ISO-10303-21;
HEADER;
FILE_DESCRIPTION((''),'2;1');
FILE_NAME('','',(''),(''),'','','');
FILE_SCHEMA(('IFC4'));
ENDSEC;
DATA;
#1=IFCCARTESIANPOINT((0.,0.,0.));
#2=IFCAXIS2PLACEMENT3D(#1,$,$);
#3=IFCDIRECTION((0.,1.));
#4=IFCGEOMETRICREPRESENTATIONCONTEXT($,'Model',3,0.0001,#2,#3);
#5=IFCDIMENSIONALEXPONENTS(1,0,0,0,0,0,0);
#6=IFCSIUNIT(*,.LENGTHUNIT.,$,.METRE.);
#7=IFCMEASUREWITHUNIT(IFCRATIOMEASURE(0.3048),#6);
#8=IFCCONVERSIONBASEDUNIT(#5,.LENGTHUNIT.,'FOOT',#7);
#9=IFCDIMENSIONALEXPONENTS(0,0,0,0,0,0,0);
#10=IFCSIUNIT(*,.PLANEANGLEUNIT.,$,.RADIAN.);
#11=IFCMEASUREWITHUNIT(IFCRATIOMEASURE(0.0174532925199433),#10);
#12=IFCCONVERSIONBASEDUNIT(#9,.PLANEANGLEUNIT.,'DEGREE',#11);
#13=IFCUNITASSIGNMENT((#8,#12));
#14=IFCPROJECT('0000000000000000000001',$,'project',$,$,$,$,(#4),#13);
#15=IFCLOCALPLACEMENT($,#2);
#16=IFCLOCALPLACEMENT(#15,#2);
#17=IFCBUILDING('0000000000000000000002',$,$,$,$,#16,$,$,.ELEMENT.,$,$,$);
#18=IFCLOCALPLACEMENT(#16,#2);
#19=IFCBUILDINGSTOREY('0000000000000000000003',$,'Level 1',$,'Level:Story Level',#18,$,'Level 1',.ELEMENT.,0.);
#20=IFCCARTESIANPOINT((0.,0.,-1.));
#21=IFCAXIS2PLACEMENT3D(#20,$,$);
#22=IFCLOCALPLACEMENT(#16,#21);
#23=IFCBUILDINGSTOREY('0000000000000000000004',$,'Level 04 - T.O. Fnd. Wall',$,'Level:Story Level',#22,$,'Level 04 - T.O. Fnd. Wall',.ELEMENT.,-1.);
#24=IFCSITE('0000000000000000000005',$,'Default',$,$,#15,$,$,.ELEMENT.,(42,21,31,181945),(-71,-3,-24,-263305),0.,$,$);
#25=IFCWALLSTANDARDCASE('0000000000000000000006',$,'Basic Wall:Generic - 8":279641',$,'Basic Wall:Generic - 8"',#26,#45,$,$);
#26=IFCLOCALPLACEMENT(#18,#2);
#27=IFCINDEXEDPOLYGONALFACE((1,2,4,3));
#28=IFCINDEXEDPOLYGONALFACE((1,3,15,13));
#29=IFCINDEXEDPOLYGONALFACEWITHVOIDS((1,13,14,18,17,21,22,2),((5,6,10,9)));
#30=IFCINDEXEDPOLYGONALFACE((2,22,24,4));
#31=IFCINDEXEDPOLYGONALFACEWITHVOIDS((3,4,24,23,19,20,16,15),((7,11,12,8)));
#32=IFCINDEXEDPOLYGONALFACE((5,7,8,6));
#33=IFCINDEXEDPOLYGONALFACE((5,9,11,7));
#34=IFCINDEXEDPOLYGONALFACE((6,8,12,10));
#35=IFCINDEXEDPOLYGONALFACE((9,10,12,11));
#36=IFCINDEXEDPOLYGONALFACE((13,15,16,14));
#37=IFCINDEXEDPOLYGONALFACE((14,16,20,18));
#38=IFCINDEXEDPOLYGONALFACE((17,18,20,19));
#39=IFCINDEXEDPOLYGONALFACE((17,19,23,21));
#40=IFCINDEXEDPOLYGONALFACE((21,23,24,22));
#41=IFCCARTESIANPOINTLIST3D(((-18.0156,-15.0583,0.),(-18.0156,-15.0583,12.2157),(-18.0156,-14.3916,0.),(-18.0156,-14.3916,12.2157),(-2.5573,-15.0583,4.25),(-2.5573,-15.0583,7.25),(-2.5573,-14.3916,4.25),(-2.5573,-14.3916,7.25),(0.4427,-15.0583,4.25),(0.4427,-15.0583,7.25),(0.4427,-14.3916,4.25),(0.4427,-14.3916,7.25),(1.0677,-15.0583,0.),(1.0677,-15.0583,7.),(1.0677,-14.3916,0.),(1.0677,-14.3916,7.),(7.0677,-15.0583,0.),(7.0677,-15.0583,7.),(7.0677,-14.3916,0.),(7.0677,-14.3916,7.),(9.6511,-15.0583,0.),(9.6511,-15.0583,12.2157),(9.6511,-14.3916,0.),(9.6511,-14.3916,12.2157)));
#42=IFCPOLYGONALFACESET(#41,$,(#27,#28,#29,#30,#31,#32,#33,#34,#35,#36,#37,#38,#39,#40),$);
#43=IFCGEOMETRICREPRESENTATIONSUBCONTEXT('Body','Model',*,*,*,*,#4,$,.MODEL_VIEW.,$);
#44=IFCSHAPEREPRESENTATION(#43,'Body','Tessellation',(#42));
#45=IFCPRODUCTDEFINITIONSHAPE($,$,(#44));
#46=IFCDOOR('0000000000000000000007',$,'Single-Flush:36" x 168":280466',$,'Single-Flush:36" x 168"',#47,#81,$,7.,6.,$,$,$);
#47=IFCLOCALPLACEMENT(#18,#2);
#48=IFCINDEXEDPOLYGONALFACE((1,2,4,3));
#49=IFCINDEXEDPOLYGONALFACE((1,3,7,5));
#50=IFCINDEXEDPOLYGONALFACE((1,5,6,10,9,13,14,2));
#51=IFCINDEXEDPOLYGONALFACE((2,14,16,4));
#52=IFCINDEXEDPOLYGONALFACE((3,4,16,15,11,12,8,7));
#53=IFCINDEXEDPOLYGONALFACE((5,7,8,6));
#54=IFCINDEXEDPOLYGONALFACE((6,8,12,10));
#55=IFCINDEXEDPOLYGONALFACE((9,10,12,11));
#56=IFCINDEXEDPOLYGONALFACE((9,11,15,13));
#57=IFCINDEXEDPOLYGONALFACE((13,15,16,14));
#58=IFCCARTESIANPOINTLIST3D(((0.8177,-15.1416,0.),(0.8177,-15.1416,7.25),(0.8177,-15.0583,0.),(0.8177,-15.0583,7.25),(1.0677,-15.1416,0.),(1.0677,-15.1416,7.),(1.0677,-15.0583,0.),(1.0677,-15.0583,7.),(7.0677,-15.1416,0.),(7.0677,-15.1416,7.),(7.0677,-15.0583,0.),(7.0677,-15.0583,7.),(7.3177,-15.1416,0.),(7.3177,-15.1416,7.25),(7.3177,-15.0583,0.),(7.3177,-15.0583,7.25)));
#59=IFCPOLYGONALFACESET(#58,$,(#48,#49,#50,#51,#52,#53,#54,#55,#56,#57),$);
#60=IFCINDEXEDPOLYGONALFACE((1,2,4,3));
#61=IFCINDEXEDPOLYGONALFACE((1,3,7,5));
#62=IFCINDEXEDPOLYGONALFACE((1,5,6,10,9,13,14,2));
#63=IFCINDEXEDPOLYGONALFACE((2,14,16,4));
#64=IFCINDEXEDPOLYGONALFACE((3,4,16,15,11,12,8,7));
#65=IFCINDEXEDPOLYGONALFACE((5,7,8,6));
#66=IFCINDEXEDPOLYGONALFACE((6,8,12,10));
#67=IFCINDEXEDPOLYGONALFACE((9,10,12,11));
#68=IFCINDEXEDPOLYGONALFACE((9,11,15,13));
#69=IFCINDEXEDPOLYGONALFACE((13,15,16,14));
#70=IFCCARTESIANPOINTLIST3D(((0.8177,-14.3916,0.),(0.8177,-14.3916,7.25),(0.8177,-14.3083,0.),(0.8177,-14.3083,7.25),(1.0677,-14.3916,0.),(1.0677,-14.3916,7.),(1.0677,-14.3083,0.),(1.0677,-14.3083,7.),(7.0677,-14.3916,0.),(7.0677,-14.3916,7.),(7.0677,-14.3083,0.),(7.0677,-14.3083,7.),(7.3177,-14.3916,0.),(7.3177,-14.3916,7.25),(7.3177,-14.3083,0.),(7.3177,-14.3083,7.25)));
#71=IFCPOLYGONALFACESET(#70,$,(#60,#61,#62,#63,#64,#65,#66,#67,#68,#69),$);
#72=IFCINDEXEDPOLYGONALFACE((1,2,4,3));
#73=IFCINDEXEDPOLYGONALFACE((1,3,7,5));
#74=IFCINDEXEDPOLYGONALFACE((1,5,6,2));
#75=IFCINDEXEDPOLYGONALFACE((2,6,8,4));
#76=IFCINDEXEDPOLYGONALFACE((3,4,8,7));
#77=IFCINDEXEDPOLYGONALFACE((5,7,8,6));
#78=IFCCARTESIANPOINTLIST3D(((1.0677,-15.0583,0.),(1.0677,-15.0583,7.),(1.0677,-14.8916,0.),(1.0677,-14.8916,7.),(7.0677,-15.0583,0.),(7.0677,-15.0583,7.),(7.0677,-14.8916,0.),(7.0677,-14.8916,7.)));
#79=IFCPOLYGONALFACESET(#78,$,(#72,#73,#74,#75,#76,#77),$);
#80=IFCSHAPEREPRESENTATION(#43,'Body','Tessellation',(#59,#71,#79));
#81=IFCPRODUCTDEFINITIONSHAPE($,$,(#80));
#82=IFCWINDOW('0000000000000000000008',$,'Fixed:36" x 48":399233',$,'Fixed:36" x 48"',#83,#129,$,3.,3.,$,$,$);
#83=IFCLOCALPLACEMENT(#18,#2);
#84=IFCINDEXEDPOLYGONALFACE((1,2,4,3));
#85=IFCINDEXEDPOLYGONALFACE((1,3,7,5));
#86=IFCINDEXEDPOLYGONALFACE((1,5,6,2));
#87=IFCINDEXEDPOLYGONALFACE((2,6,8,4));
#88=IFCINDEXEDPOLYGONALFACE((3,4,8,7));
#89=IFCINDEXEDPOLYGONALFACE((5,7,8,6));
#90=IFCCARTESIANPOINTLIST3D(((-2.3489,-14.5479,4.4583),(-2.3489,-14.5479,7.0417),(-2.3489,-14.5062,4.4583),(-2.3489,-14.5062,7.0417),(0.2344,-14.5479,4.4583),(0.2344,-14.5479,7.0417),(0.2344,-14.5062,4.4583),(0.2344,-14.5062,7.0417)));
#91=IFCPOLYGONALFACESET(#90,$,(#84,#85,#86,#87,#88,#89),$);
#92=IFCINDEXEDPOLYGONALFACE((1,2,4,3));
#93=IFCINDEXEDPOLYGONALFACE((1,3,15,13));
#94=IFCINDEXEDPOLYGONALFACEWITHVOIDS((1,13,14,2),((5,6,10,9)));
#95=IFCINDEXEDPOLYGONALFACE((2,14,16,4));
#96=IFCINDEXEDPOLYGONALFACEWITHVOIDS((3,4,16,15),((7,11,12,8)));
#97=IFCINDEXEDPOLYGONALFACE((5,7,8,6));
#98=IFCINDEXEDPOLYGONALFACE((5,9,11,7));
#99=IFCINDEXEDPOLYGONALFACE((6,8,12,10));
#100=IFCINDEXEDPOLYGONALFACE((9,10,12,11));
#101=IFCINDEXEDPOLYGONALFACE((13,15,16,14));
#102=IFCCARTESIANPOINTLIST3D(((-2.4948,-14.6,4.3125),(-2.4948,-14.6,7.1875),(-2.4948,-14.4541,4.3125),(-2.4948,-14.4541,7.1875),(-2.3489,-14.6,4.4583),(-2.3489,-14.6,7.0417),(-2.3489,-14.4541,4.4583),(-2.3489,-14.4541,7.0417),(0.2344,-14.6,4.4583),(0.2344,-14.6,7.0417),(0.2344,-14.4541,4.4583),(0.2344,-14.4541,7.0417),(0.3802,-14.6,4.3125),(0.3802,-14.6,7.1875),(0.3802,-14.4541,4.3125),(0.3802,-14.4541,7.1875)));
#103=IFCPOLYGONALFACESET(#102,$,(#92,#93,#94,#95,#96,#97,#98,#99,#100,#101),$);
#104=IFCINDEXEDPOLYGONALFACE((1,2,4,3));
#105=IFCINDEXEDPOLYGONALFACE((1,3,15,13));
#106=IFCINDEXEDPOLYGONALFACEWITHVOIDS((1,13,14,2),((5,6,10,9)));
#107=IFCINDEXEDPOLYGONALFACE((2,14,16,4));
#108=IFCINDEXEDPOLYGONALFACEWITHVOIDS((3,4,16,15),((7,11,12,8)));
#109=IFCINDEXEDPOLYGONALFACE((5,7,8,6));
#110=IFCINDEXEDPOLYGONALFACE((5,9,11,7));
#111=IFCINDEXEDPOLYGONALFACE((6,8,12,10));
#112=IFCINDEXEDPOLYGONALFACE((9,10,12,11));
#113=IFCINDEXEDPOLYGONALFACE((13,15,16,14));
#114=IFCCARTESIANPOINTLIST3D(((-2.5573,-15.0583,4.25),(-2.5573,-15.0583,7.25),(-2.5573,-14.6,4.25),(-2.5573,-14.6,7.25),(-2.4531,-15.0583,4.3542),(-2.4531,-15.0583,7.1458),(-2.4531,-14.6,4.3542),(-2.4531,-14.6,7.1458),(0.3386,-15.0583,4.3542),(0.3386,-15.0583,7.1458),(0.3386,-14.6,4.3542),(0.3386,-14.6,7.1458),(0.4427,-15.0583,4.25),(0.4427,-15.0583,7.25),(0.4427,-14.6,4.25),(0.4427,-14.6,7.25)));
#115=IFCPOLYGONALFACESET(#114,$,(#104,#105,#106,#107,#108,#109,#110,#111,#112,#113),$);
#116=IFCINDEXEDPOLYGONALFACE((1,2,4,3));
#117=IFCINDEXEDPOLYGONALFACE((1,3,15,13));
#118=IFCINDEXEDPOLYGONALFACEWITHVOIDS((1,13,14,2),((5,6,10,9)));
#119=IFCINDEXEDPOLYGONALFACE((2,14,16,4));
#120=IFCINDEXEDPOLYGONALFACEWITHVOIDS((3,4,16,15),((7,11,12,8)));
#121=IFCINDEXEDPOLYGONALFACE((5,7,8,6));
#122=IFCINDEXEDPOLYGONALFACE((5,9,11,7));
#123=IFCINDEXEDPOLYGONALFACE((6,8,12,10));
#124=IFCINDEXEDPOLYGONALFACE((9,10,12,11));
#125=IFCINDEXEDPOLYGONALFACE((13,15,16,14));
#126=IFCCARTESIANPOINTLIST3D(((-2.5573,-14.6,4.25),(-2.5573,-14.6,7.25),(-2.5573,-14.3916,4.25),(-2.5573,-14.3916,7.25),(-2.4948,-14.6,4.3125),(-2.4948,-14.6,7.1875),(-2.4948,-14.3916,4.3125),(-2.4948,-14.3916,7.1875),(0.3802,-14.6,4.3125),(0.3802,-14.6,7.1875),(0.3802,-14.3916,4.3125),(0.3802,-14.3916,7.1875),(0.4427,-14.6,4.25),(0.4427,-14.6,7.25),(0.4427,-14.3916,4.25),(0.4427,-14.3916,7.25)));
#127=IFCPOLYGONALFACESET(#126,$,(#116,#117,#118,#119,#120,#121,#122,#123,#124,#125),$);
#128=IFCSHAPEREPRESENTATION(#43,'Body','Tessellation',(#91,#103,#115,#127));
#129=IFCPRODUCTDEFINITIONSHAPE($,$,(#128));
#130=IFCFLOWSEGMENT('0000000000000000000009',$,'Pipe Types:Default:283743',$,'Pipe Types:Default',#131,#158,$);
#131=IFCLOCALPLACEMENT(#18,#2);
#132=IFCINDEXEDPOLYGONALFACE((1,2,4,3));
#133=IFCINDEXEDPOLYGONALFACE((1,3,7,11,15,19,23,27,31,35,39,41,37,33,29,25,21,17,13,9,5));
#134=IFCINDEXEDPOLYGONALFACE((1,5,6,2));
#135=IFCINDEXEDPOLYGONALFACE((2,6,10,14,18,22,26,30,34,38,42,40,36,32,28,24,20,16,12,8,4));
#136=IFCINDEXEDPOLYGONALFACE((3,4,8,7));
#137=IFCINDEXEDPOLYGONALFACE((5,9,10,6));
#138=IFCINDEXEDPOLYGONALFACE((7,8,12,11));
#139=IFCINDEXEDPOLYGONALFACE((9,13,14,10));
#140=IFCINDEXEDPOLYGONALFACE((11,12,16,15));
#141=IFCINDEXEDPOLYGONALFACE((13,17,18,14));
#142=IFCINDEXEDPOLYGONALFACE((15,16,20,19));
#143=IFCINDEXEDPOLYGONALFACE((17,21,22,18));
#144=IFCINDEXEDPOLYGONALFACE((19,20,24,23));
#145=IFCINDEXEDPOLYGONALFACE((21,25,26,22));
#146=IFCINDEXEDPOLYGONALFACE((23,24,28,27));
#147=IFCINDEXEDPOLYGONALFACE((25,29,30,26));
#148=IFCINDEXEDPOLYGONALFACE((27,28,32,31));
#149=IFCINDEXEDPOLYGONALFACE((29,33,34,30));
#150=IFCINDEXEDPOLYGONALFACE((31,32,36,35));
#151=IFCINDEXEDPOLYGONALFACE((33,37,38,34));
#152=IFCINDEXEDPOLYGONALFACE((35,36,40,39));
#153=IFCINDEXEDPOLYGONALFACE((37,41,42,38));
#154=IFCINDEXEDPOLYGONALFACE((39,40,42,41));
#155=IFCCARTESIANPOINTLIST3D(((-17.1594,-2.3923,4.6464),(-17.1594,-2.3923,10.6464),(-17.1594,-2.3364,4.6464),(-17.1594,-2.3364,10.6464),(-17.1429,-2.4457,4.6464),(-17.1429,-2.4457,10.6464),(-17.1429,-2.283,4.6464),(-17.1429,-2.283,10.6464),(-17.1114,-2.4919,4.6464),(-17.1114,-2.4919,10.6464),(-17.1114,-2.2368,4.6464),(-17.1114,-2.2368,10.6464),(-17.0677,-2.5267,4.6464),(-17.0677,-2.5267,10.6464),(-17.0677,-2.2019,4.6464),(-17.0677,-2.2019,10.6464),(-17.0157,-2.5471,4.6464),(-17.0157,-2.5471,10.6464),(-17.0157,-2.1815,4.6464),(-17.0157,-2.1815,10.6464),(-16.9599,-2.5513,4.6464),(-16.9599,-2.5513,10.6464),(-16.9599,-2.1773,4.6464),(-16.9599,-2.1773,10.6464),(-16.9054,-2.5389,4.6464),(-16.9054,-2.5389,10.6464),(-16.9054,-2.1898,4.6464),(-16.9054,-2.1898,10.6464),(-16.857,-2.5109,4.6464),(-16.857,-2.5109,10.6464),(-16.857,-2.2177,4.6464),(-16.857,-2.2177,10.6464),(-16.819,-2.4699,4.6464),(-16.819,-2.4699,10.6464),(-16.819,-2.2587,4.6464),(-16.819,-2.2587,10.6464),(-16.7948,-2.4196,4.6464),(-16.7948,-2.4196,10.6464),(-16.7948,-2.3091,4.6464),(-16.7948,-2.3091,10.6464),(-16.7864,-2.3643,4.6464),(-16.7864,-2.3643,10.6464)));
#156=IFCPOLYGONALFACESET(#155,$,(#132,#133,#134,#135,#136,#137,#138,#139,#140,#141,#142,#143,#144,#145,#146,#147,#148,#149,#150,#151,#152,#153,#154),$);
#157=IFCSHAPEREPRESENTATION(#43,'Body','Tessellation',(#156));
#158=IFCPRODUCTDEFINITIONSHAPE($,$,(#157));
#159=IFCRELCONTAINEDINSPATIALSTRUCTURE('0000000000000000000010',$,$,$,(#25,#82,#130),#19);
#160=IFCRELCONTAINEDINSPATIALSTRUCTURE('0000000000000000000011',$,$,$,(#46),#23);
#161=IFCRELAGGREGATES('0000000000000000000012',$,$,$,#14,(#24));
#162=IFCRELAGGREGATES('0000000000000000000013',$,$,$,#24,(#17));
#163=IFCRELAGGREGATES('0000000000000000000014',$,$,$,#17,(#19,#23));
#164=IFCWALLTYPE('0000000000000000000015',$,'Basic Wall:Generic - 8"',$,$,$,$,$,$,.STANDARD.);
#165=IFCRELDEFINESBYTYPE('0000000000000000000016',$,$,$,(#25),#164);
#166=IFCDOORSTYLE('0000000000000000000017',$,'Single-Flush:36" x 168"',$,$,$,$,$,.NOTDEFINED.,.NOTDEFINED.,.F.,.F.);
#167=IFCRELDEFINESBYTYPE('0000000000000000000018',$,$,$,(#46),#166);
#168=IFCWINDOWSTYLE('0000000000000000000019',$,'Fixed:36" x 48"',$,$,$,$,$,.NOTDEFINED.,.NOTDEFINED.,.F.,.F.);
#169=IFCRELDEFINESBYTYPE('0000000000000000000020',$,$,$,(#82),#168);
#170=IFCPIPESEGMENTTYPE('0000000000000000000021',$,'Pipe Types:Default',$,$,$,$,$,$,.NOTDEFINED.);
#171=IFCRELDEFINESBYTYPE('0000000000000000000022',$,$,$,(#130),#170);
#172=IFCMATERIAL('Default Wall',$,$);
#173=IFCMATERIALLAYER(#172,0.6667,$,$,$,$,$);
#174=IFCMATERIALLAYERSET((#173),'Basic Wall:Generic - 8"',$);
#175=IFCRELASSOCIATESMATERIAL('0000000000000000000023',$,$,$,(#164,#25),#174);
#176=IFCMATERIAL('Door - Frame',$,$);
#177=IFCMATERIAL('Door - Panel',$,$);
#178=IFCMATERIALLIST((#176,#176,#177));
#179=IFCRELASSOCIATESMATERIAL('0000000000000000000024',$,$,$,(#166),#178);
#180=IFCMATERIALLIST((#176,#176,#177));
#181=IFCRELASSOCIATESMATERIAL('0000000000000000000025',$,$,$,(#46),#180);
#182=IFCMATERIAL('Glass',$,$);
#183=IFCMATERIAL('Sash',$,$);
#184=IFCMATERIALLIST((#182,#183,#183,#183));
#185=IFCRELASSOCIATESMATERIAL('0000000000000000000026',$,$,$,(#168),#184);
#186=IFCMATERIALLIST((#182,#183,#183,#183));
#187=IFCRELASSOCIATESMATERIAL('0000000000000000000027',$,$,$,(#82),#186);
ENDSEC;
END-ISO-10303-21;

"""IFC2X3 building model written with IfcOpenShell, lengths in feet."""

from ifc_helpers import new_model, entity, si_unit, converted_unit, direction, frame, frame_2d, origin, origin_2d_with_axis, place, context, subcontext, project, spatial, polyline, rectangle, circle, outline, extrude, source, transform, mapped, material, material_list, layer, layer_set, layer_usage, type_object, type_shapes, element, fill, save


model = new_model("IFC2X3")

# Units and contexts
model_context = context("Model", 3, precision=0.0001, world=origin(), true_north=direction((0.0, 1.0)))
body_context = subcontext(model_context, "Body", "Model", "MODEL_VIEW")
ifc_project = project(units=[converted_unit("LENGTHUNIT", "FOOT", entity("IfcRatioMeasure", 0.3048), si_unit("LENGTHUNIT", "METRE"), dimensions=[1, 0, 0, 0, 0, 0, 0]), converted_unit("PLANEANGLEUNIT", "DEGREE", entity("IfcRatioMeasure", 0.0174532925199433), si_unit("PLANEANGLEUNIT", "RADIAN"), dimensions=[0, 0, 0, 0, 0, 0, 0])], contexts=[model_context])

# Site, building, storey
site_placement = place(None, origin())
site = spatial("IfcSite", under=ifc_project, at=site_placement, Name="Default", CompositionType="ELEMENT", RefLatitude=(42, 21, 31, 181945), RefLongitude=(-71, -3, -24, -263305), RefElevation=0.0)
building_placement = place(site_placement, origin())
building = spatial("IfcBuilding", under=site, at=building_placement, CompositionType="ELEMENT")
storey_1_placement = place(building_placement, origin())
storey_1 = spatial("IfcBuildingStorey", under=building, at=storey_1_placement, Name="Level 1", ObjectType="Level:Story Level", LongName="Level 1", CompositionType="ELEMENT", Elevation=0.0)

# Shared definitions
ifc_material_1 = material(Name="Default Wall")
ifc_layer = layer(ifc_material_1, 0.6667)
ifc_layer_set = layer_set([ifc_layer], Name="Basic Wall:Generic - 8\"")
wall_type = type_object("IfcWallType", Name="Basic Wall:Generic - 8\"", PredefinedType="STANDARD", material=ifc_layer_set)

# Wall, openings
ifc_layer_usage_1 = layer_usage(ifc_layer_set, "AXIS2", "NEGATIVE", 0.3333)
wall_1_placement = place(storey_1_placement, frame((9.6511, -14.725, 0.0), z_axis=(0.0, 0.0, 1.0), x_axis=(-1.0, 0.0, 0.0)))
wall_1 = element("IfcWallStandardCase", 1, at=wall_1_placement, inside=storey_1, type_object=wall_type, material=ifc_layer_usage_1, Name="Basic Wall:Generic - 8\":279641", ObjectType="Basic Wall:Generic - 8\"", context=body_context, shape_type="SweptSolid", body=[
    extrude(rectangle(XDim=27.6667, YDim=0.6667, at=frame_2d((13.8333, 0.0), x_axis=(-1.0, 0.0))), origin(), (0.0, 0.0, 1.0), 12.2157),
])
opening_1_placement = place(wall_1_placement, frame((2.5833, -0.3333, 0.0)))
opening_1 = element("IfcOpeningElement", 2, at=opening_1_placement, cuts=wall_1, ObjectType="Opening", context=body_context, shape_type="SweptSolid", body=[
    extrude(rectangle(XDim=6.0, YDim=7.0, at=frame_2d((3.5, 3.0), x_axis=(0.0, 1.0))), frame((0.0, 0.0, 0.0), z_axis=(0.0, 1.0, 0.0), x_axis=(0.0, 0.0, 1.0)), (0.0, 0.0, 1.0), 0.6667),
])
opening_2_placement = place(wall_1_placement, frame((12.2083, 0.3333, 4.25)))
opening_2 = element("IfcOpeningElement", 3, at=opening_2_placement, cuts=wall_1, ObjectType="Opening", context=body_context, shape_type="SweptSolid", body=[
    extrude(rectangle(XDim=3.0, YDim=3.0, at=frame_2d((1.5, 1.5), x_axis=(-1.0, 0.0))), frame((0.0, 0.0, 0.0), z_axis=(0.0, -1.0, 0.0), x_axis=(0.0, 0.0, 1.0)), (0.0, 0.0, 1.0), 0.6667),
])

# Shared definitions
storey_2_placement = place(building_placement, frame((0.0, 0.0, -1.0)))
storey_2 = spatial("IfcBuildingStorey", under=building, at=storey_2_placement, Name="Level 04 - T.O. Fnd. Wall", ObjectType="Level:Story Level", LongName="Level 04 - T.O. Fnd. Wall", CompositionType="ELEMENT", Elevation=-1.0)

# Door
ifc_material_2 = material(Name="Door - Frame")
ifc_material_3 = material(Name="Door - Panel")
ifc_material_list_1 = material_list([ifc_material_2, ifc_material_2, ifc_material_3])
ifc_material_list_2 = material_list([ifc_material_2, ifc_material_2, ifc_material_3])
door_style = type_object("IfcDoorStyle", Name="Single-Flush:36\" x 168\"", ConstructionType="NOTDEFINED", OperationType="NOTDEFINED", ParameterTakesPrecedence=False, Sizeable=False, material=ifc_material_list_2)
shared_shape_1 = source(origin(), body_context, "Body", "SweptSolid", [
    extrude(outline(polyline([(-3.25, -3.6875), (3.25, -3.6875), (3.25, 3.5625), (3.0, 3.5625), (3.0, -3.4375), (-3.0, -3.4375), (-3.0, 3.5625), (-3.25, 3.5625), (-3.25, -3.6875)])), frame((3.0, 0.6667, 3.5625), z_axis=(0.0, 1.0, 0.0), x_axis=(1.0, 0.0, 0.0)), (0.0, 0.0, 1.0), 0.0833),
    extrude(outline(polyline([(-3.6875, -3.25), (3.5625, -3.25), (3.5625, -3.0), (-3.4375, -3.0), (-3.4375, 3.0), (3.5625, 3.0), (3.5625, 3.25), (-3.6875, 3.25), (-3.6875, -3.25)])), frame((3.0, -0.0833, 3.5625), z_axis=(0.0, 1.0, 0.0), x_axis=(0.0, 0.0, -1.0)), (0.0, 0.0, 1.0), 0.0833),
    extrude(rectangle(XDim=0.1667, YDim=6.0, at=frame_2d((0.0, 0.0), x_axis=(1.0, 0.0))), frame((3.0, 0.5833, 0.0), z_axis=(0.0, 0.0, 1.0), x_axis=(0.0, 1.0, 0.0)), (0.0, 0.0, 1.0), 7.0),
])
type_shapes(door_style, [shared_shape_1])
door_placement = place(opening_1_placement, origin())
door = element("IfcDoor", 4, at=door_placement, inside=storey_2, type_object=door_style, material=ifc_material_list_1, Name="Single-Flush:36\" x 168\":280466", ObjectType="Single-Flush:36\" x 168\"", OverallHeight=7.0, OverallWidth=6.0, context=body_context, shape_type="MappedRepresentation", body=[
    mapped(shared_shape_1, transform((0.0, 0.0, 0.0), scale=1.0)),
])
fill(opening_1, door)

# Window
ifc_material_4 = material(Name="Glass")
ifc_material_5 = material(Name="Sash")
ifc_material_list_3 = material_list([ifc_material_4, ifc_material_5, ifc_material_5, ifc_material_5])
ifc_material_list_4 = material_list([ifc_material_4, ifc_material_5, ifc_material_5, ifc_material_5])
window_style = type_object("IfcWindowStyle", Name="Fixed:36\" x 48\"", ConstructionType="NOTDEFINED", OperationType="NOTDEFINED", ParameterTakesPrecedence=False, Sizeable=False, material=ifc_material_list_4)
shared_shape_2 = source(origin(), body_context, "Body", "SweptSolid", [
    extrude(rectangle(XDim=0.0417, YDim=2.5833, at=frame_2d((0.0, 0.0), x_axis=(1.0, 0.0))), frame((1.5, 0.5312, 0.2083), z_axis=(0.0, 0.0, 1.0), x_axis=(0.0, 1.0, 0.0)), (0.0, 0.0, 1.0), 2.5833),
    extrude(outline(polyline([(-1.4375, -1.4375), (1.4375, -1.4375), (1.4375, 1.4375), (-1.4375, 1.4375), (-1.4375, -1.4375)]), holes=[polyline([(-1.2917, -1.2917), (-1.2917, 1.2917), (1.2917, 1.2917), (1.2917, -1.2917), (-1.2917, -1.2917)])]), frame((1.5, 0.4583, 1.5), z_axis=(0.0, 1.0, 0.0), x_axis=(1.0, 0.0, 0.0)), (0.0, 0.0, 1.0), 0.1458),
    extrude(outline(polyline([(-1.5, -1.5), (1.5, -1.5), (1.5, 1.5), (-1.5, 1.5), (-1.5, -1.5)]), holes=[polyline([(-1.3958, -1.3958), (-1.3958, 1.3958), (1.3958, 1.3958), (1.3958, -1.3958), (-1.3958, -1.3958)])]), frame((1.5, 0.0, 1.5), z_axis=(0.0, 1.0, 0.0), x_axis=(1.0, 0.0, 0.0)), (0.0, 0.0, 1.0), 0.4583),
    extrude(outline(polyline([(-1.5, -1.5), (1.5, -1.5), (1.5, 1.5), (-1.5, 1.5), (-1.5, -1.5)]), holes=[polyline([(-1.4375, -1.4375), (-1.4375, 1.4375), (1.4375, 1.4375), (1.4375, -1.4375), (-1.4375, -1.4375)])]), frame((1.5, 0.4583, 1.5), z_axis=(0.0, 1.0, 0.0), x_axis=(0.0, 0.0, -1.0)), (0.0, 0.0, 1.0), 0.2083),
])
type_shapes(window_style, [shared_shape_2])
window_placement = place(opening_2_placement, frame((0.0, 0.0, 0.0), z_axis=(0.0, 0.0, 1.0), x_axis=(-1.0, 0.0, 0.0)))
window = element("IfcWindow", 5, at=window_placement, inside=storey_1, type_object=window_style, material=ifc_material_list_3, Name="Fixed:36\" x 48\":399233", ObjectType="Fixed:36\" x 48\"", OverallHeight=3.0, OverallWidth=3.0, context=body_context, shape_type="MappedRepresentation", body=[
    mapped(shared_shape_2, transform((0.0, 0.0, 0.0), scale=1.0)),
])
fill(opening_2, window)

# Flow segment
pipe_segment_type = type_object("IfcPipeSegmentType", Name="Pipe Types:Default", PredefinedType="NOTDEFINED")
flow_segment_1_placement = place(storey_1_placement, origin())
element("IfcFlowSegment", 6, at=flow_segment_1_placement, inside=storey_1, type_object=pipe_segment_type, Name="Pipe Types:Default:283743", ObjectType="Pipe Types:Default", context=body_context, shape_type="SweptSolid", body=[
    extrude(circle(Radius=0.1875, at=origin_2d_with_axis()), frame((-16.9739, -2.3643, 4.6464)), (0.0, 0.0, 1.0), 6.0),
])

save(model, "model.ifc")
